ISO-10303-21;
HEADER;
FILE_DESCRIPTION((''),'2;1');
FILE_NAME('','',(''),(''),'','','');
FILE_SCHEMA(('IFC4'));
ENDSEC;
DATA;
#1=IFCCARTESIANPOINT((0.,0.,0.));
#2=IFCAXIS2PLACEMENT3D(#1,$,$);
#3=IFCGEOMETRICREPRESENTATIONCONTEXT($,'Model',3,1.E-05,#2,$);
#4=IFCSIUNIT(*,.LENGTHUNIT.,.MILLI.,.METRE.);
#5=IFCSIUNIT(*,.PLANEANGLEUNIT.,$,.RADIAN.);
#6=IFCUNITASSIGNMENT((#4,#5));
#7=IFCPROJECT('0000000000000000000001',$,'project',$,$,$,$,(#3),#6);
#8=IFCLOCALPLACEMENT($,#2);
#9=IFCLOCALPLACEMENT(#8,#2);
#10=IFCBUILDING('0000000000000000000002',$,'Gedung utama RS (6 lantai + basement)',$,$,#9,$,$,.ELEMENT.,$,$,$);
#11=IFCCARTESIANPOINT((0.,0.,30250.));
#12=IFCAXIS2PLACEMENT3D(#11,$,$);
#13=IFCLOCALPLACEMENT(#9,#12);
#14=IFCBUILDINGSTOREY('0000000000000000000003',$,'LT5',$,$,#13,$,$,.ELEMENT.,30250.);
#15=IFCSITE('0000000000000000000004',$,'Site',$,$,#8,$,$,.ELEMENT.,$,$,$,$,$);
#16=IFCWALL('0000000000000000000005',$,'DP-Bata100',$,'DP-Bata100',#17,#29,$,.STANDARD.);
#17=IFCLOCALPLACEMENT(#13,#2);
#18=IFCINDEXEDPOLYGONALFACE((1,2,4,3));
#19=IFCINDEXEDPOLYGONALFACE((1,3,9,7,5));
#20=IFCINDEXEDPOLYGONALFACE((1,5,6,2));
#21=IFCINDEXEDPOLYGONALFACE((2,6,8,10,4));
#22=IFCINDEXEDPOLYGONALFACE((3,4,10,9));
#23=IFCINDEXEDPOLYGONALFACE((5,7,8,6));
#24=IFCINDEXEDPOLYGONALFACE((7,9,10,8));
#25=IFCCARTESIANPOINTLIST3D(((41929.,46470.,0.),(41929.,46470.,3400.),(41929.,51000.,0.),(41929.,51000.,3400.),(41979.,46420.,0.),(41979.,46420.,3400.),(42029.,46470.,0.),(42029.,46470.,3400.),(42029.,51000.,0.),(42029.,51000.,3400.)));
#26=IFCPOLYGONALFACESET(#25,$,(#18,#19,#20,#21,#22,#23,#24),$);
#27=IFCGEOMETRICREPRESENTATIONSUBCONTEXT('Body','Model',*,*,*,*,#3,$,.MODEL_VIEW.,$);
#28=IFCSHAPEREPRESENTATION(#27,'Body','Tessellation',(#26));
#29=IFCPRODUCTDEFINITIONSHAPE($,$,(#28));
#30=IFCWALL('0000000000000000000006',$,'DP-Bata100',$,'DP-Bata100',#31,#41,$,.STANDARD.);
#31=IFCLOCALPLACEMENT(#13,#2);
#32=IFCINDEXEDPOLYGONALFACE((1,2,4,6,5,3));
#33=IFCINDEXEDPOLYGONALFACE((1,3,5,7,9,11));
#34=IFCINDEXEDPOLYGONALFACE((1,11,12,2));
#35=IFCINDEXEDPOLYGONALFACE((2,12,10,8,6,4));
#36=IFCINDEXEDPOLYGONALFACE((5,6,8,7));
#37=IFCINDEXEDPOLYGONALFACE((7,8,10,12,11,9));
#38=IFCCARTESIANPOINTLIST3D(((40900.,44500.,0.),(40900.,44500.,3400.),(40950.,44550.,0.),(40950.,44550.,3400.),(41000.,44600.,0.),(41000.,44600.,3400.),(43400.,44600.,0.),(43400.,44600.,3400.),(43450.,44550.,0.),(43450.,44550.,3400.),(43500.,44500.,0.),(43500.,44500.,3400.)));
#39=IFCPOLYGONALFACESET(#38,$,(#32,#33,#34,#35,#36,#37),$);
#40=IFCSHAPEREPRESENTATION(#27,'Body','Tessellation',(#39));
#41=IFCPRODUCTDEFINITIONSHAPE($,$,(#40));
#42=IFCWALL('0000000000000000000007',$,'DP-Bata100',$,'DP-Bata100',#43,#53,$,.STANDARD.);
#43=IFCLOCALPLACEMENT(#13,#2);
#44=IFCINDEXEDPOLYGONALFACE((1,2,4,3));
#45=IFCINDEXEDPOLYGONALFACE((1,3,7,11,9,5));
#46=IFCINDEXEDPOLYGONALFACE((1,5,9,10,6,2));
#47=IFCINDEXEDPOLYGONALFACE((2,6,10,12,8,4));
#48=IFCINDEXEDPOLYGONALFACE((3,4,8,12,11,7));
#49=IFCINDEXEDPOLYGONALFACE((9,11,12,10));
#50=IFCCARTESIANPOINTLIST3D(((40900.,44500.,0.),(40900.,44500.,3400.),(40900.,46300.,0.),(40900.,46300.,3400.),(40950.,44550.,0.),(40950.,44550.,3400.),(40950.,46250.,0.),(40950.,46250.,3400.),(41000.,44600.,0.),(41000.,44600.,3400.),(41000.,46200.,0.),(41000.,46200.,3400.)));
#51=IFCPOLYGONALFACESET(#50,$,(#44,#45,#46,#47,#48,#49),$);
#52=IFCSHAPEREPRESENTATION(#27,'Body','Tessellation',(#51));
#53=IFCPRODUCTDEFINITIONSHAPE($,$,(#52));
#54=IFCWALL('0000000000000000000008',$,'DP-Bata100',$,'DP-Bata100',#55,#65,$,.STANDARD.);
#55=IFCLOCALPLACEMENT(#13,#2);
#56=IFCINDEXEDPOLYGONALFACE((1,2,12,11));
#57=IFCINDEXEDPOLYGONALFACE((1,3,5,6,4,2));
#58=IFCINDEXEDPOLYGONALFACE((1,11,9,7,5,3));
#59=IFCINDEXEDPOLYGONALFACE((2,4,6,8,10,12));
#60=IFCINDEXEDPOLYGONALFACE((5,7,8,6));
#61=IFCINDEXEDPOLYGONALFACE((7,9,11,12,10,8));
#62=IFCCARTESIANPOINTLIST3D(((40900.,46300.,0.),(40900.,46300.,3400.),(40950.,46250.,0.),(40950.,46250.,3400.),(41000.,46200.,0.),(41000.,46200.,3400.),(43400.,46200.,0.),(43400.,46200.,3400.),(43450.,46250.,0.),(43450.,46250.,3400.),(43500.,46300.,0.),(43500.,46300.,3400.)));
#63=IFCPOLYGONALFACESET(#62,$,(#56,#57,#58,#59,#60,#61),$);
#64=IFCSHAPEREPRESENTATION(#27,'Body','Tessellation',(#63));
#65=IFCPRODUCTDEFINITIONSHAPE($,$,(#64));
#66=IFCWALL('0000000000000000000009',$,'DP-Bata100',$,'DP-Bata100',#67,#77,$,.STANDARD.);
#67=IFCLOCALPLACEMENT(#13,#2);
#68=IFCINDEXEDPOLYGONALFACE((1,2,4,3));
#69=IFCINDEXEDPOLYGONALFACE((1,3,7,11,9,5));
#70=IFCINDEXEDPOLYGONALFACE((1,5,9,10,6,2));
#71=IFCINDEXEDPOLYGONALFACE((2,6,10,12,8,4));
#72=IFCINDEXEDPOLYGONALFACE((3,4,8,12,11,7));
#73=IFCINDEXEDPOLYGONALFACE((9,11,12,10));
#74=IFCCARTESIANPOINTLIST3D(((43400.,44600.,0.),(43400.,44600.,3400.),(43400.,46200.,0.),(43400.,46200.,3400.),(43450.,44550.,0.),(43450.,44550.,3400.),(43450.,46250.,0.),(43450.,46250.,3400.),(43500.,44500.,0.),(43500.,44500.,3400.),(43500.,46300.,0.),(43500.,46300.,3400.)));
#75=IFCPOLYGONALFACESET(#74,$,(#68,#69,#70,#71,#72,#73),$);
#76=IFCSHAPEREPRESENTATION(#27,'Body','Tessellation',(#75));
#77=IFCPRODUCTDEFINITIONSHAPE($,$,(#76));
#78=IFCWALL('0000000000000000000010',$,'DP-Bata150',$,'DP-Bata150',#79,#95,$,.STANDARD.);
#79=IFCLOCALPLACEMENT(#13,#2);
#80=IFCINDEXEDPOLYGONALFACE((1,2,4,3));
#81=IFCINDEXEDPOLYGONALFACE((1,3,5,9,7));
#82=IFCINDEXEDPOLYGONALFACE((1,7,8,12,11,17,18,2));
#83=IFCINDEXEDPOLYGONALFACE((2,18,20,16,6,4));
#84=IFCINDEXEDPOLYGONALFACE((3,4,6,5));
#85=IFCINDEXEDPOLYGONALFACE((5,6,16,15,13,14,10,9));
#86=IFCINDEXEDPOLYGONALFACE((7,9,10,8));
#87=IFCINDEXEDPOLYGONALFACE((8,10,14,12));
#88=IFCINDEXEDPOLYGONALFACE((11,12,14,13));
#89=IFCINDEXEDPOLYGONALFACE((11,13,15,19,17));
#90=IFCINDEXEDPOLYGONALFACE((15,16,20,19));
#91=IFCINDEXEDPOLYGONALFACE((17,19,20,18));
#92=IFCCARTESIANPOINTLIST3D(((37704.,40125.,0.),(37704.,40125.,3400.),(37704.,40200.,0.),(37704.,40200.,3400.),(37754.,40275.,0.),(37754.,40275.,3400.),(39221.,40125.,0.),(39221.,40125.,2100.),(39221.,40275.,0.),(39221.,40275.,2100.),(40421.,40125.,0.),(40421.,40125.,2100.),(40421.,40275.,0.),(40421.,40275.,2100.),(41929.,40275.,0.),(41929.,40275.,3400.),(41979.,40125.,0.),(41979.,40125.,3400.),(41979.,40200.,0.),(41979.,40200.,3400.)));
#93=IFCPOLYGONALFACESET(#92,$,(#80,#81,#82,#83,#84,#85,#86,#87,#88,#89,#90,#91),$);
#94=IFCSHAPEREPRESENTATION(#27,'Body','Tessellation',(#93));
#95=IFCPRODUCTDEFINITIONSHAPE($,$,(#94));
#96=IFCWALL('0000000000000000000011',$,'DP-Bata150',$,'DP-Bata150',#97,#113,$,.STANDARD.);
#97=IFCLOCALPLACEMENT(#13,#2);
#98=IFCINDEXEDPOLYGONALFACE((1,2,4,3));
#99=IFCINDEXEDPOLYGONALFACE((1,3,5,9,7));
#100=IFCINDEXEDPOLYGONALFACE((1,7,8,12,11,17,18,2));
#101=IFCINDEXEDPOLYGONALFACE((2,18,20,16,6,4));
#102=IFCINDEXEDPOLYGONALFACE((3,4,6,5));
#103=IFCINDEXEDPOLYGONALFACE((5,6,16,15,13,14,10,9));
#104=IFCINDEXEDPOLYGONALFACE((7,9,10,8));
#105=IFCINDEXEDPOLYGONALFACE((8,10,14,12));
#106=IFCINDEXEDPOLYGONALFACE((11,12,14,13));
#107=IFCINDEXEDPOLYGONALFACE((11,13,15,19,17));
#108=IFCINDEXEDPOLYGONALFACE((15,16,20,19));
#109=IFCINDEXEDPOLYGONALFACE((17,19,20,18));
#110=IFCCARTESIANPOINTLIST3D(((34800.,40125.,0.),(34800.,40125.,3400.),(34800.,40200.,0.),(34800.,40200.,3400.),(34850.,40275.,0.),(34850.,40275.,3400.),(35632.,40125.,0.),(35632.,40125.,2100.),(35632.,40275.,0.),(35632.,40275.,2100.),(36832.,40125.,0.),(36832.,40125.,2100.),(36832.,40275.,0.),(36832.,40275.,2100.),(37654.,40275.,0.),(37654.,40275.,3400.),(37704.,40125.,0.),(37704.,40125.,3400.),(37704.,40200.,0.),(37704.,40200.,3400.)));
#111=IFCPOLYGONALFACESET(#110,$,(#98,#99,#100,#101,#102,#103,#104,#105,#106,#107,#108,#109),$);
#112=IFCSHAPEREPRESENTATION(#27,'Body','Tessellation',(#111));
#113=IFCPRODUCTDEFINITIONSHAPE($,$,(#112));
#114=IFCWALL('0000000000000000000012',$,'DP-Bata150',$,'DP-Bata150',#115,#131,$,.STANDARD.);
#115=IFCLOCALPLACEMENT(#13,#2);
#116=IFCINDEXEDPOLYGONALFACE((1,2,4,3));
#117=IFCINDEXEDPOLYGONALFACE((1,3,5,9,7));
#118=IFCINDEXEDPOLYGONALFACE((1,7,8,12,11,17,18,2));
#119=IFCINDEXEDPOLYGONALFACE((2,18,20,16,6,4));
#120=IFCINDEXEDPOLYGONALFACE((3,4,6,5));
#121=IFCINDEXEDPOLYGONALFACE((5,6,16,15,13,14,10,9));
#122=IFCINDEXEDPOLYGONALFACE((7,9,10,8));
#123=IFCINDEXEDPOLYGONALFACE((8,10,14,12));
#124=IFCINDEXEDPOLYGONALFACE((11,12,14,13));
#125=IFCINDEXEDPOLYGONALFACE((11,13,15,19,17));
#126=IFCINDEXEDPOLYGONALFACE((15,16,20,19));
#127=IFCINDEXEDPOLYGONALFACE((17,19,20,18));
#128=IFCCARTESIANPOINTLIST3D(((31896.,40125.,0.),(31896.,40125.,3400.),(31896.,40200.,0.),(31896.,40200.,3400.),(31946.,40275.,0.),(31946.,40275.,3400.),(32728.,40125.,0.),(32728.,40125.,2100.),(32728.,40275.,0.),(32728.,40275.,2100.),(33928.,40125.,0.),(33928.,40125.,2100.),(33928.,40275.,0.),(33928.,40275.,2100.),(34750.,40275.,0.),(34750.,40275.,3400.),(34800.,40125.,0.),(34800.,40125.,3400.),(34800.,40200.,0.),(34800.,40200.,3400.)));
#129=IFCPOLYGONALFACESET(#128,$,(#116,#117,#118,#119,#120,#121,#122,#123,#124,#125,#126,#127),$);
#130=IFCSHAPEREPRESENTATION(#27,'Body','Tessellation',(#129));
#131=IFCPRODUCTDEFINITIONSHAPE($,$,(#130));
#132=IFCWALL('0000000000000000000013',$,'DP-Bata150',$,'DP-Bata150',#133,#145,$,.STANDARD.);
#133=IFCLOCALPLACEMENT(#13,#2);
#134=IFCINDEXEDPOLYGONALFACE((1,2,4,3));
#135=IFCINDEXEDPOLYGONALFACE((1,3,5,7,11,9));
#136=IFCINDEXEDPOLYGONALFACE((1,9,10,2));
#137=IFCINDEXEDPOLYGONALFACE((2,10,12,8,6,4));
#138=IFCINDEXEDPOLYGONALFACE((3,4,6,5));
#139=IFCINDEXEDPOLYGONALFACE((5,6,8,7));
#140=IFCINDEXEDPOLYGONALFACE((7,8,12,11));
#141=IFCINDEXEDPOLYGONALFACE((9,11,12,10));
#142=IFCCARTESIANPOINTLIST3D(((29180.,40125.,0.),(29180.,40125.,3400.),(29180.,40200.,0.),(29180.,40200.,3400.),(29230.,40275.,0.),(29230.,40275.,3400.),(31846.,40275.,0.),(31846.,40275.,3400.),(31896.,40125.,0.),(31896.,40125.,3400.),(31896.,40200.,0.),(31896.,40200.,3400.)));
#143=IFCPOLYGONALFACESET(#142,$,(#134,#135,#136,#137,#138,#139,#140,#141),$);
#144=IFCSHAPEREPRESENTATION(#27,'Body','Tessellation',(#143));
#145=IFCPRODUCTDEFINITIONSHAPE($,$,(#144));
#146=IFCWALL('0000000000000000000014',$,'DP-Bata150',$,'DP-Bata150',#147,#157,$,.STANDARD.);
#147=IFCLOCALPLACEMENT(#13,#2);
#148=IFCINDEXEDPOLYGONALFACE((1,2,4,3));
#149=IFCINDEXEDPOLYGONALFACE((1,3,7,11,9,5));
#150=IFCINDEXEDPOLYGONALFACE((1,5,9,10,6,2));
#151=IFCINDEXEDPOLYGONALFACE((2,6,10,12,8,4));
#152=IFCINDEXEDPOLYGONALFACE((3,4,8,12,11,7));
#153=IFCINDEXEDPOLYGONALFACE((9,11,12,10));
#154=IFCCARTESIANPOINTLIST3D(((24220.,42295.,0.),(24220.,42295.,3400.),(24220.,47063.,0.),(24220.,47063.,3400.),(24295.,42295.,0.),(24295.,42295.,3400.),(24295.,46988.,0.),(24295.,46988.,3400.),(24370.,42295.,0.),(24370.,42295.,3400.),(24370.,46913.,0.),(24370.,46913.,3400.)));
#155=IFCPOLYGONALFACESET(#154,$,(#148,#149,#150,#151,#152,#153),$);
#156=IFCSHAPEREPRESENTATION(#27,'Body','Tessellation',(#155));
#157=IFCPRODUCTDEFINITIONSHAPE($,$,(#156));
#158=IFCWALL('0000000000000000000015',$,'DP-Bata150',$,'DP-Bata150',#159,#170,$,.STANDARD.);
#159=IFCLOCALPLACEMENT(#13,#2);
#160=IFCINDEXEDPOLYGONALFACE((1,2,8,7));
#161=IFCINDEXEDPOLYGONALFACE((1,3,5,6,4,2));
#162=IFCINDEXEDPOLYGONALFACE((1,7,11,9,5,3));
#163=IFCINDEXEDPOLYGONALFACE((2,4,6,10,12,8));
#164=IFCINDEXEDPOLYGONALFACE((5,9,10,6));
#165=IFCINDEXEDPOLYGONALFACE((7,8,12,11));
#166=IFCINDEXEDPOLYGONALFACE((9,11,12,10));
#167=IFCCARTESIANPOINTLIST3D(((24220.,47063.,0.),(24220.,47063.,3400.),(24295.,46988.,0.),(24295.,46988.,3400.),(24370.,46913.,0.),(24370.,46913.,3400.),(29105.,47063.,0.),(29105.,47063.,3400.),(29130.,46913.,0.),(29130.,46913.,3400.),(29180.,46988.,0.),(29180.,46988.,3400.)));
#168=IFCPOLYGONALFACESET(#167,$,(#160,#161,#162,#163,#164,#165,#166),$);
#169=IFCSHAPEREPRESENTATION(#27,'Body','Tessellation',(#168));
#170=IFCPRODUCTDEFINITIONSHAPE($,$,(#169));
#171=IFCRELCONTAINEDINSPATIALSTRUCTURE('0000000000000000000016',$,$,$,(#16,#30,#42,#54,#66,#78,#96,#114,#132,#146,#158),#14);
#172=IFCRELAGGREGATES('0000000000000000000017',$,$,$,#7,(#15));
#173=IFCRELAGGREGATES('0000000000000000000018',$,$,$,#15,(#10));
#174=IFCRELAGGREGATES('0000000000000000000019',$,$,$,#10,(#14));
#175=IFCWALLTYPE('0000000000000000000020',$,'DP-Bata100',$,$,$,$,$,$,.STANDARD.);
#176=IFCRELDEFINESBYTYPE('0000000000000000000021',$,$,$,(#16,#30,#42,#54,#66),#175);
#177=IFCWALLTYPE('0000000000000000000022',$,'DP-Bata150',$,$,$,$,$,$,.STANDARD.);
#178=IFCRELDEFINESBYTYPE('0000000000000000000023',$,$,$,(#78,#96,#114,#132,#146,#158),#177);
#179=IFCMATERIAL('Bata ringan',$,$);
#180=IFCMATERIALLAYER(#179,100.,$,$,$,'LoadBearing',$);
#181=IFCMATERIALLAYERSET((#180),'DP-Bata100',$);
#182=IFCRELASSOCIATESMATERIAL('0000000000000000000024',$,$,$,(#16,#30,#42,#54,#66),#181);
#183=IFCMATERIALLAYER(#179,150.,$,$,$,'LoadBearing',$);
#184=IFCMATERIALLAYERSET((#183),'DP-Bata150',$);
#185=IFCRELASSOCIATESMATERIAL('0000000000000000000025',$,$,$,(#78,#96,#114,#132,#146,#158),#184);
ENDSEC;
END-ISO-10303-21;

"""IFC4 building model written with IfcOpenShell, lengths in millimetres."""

from ifc_helpers import new_model, si_unit, frame, frame_2d, origin, place, context, subcontext, project, spatial, polyline, rectangle, outline, extrude, material, layer, layer_set, layer_usage, type_object, element, save


model = new_model("IFC4")

# Units and contexts
model_context = context("Model", 3, precision=1e-05, world=origin())
body_context = subcontext(model_context, "Body", "Model", "MODEL_VIEW")
ifc_project = project(units=[si_unit("LENGTHUNIT", "METRE", prefix="MILLI"), si_unit("PLANEANGLEUNIT", "RADIAN")], contexts=[model_context])

# Site, building, storey
site_placement = place(None, origin())
site = spatial("IfcSite", under=ifc_project, at=site_placement, Name="Site", CompositionType="ELEMENT")
building_placement = place(site_placement, origin())
building = spatial("IfcBuilding", under=site, at=building_placement, Name="Gedung utama RS (6 lantai + basement)", CompositionType="ELEMENT")
storey_placement = place(building_placement, frame((0.0, 0.0, 30250.0)))
storey = spatial("IfcBuildingStorey", under=building, at=storey_placement, Name="LT5", CompositionType="ELEMENT", Elevation=30250.0)

# Walls
ifc_material_1 = material(Name="Bata ringan")
ifc_layer_1 = layer(ifc_material_1, 100.0, Category="LoadBearing")
ifc_layer_set_1 = layer_set([ifc_layer_1], Name="DP-Bata100")
ifc_layer_usage_1 = layer_usage(ifc_layer_set_1, "AXIS2", "NEGATIVE", 50.0)
wall_type_1 = type_object("IfcWallType", Name="DP-Bata100", PredefinedType="STANDARD")
wall_1_placement = place(storey_placement, frame((41979.0, 51000.0, 0.0), z_axis=(0.0, 0.0, 1.0), x_axis=(0.0, -1.0, 0.0)))
element("IfcWall", 1, at=wall_1_placement, inside=storey, type_object=wall_type_1, material=ifc_layer_usage_1, Name="DP-Bata100", ObjectType="DP-Bata100", PredefinedType="STANDARD", context=body_context, shape_type="SweptSolid", body=[
    extrude(outline(polyline([(0.0, -50.0), (0.0, 50.0), (4530.0, 50.0), (4580.0, 0.0), (4530.0, -50.0), (0.0, -50.0)])), origin(), (0.0, 0.0, 1.0), 3400.0),
])
wall_2_placement = place(storey_placement, frame((43450.0, 44550.0, 0.0), z_axis=(0.0, 0.0, 1.0), x_axis=(-1.0, 0.0, 0.0)))
element("IfcWall", 2, at=wall_2_placement, inside=storey, type_object=wall_type_1, material=ifc_layer_usage_1, Name="DP-Bata100", ObjectType="DP-Bata100", PredefinedType="STANDARD", context=body_context, shape_type="SweptSolid", body=[
    extrude(outline(polyline([(50.0, -50.0), (0.0, 0.0), (-50.0, 50.0), (2550.0, 50.0), (2500.0, 0.0), (2450.0, -50.0), (50.0, -50.0)])), origin(), (0.0, 0.0, 1.0), 3400.0),
])
wall_3_placement = place(storey_placement, frame((40950.0, 44550.0, 0.0), z_axis=(0.0, 0.0, 1.0), x_axis=(0.0, 1.0, 0.0)))
element("IfcWall", 3, at=wall_3_placement, inside=storey, type_object=wall_type_1, material=ifc_layer_usage_1, Name="DP-Bata100", ObjectType="DP-Bata100", PredefinedType="STANDARD", context=body_context, shape_type="SweptSolid", body=[
    extrude(outline(polyline([(50.0, -50.0), (0.0, 0.0), (-50.0, 50.0), (1750.0, 50.0), (1700.0, 0.0), (1650.0, -50.0), (50.0, -50.0)])), origin(), (0.0, 0.0, 1.0), 3400.0),
])
wall_4_placement = place(storey_placement, frame((40950.0, 46250.0, 0.0), z_axis=(0.0, 0.0, 1.0), x_axis=(1.0, 0.0, 0.0)))
element("IfcWall", 4, at=wall_4_placement, inside=storey, type_object=wall_type_1, material=ifc_layer_usage_1, Name="DP-Bata100", ObjectType="DP-Bata100", PredefinedType="STANDARD", context=body_context, shape_type="SweptSolid", body=[
    extrude(outline(polyline([(50.0, -50.0), (0.0, 0.0), (-50.0, 50.0), (2550.0, 50.0), (2500.0, 0.0), (2450.0, -50.0), (50.0, -50.0)])), origin(), (0.0, 0.0, 1.0), 3400.0),
])
wall_5_placement = place(storey_placement, frame((43450.0, 46250.0, 0.0), z_axis=(0.0, 0.0, 1.0), x_axis=(0.0, -1.0, 0.0)))
element("IfcWall", 5, at=wall_5_placement, inside=storey, type_object=wall_type_1, material=ifc_layer_usage_1, Name="DP-Bata100", ObjectType="DP-Bata100", PredefinedType="STANDARD", context=body_context, shape_type="SweptSolid", body=[
    extrude(outline(polyline([(50.0, -50.0), (0.0, 0.0), (-50.0, 50.0), (1750.0, 50.0), (1700.0, 0.0), (1650.0, -50.0), (50.0, -50.0)])), origin(), (0.0, 0.0, 1.0), 3400.0),
])

# Walls, openings
ifc_layer_2 = layer(ifc_material_1, 150.0, Category="LoadBearing")
ifc_layer_set_2 = layer_set([ifc_layer_2], Name="DP-Bata150")
ifc_layer_usage_2 = layer_usage(ifc_layer_set_2, "AXIS2", "NEGATIVE", 75.0)
wall_type_2 = type_object("IfcWallType", Name="DP-Bata150", PredefinedType="STANDARD")
wall_6_placement = place(storey_placement, frame((41979.0, 40200.0, 0.0), z_axis=(0.0, 0.0, 1.0), x_axis=(-1.0, 0.0, 0.0)))
wall_6 = element("IfcWall", 6, at=wall_6_placement, inside=storey, type_object=wall_type_2, material=ifc_layer_usage_2, Name="DP-Bata150", ObjectType="DP-Bata150", PredefinedType="STANDARD", context=body_context, shape_type="SweptSolid", body=[
    extrude(outline(polyline([(50.0, -75.0), (0.0, 0.0), (0.0, 75.0), (4275.0, 75.0), (4275.0, 0.0), (4225.0, -75.0), (50.0, -75.0)])), origin(), (0.0, 0.0, 1.0), 3400.0),
])
opening_1_placement = place(wall_6_placement, frame((1558.0, 0.0, 0.0), z_axis=(0.0, 0.0, 1.0), x_axis=(1.0, 0.0, 0.0)))
element("IfcOpeningElement", 7, at=opening_1_placement, cuts=wall_6, PredefinedType="OPENING", context=body_context, shape_type="SweptSolid", body=[
    extrude(rectangle(XDim=1200.0, YDim=170.0, at=frame_2d((600.0, 0.0))), origin(), (0.0, 0.0, 1.0), 2100.0),
])
wall_7_placement = place(storey_placement, frame((37704.0, 40200.0, 0.0), z_axis=(0.0, 0.0, 1.0), x_axis=(-1.0, 0.0, 0.0)))
wall_7 = element("IfcWall", 8, at=wall_7_placement, inside=storey, type_object=wall_type_2, material=ifc_layer_usage_2, Name="DP-Bata150", ObjectType="DP-Bata150", PredefinedType="STANDARD", context=body_context, shape_type="SweptSolid", body=[
    extrude(outline(polyline([(50.0, -75.0), (0.0, 0.0), (0.0, 75.0), (2904.0, 75.0), (2904.0, 0.0), (2854.0, -75.0), (50.0, -75.0)])), origin(), (0.0, 0.0, 1.0), 3400.0),
])
opening_2_placement = place(wall_7_placement, frame((872.0, 0.0, 0.0), z_axis=(0.0, 0.0, 1.0), x_axis=(1.0, 0.0, 0.0)))
element("IfcOpeningElement", 9, at=opening_2_placement, cuts=wall_7, PredefinedType="OPENING", context=body_context, shape_type="SweptSolid", body=[
    extrude(rectangle(XDim=1200.0, YDim=170.0, at=frame_2d((600.0, 0.0))), origin(), (0.0, 0.0, 1.0), 2100.0),
])
wall_8_placement = place(storey_placement, frame((34800.0, 40200.0, 0.0), z_axis=(0.0, 0.0, 1.0), x_axis=(-1.0, 0.0, 0.0)))
wall_8 = element("IfcWall", 10, at=wall_8_placement, inside=storey, type_object=wall_type_2, material=ifc_layer_usage_2, Name="DP-Bata150", ObjectType="DP-Bata150", PredefinedType="STANDARD", context=body_context, shape_type="SweptSolid", body=[
    extrude(outline(polyline([(50.0, -75.0), (0.0, 0.0), (0.0, 75.0), (2904.0, 75.0), (2904.0, 0.0), (2854.0, -75.0), (50.0, -75.0)])), origin(), (0.0, 0.0, 1.0), 3400.0),
])
opening_3_placement = place(wall_8_placement, frame((872.0, 0.0, 0.0), z_axis=(0.0, 0.0, 1.0), x_axis=(1.0, 0.0, 0.0)))
element("IfcOpeningElement", 11, at=opening_3_placement, cuts=wall_8, PredefinedType="OPENING", context=body_context, shape_type="SweptSolid", body=[
    extrude(rectangle(XDim=1200.0, YDim=170.0, at=frame_2d((600.0, 0.0))), origin(), (0.0, 0.0, 1.0), 2100.0),
])

# Walls
wall_9_placement = place(storey_placement, frame((31896.0, 40200.0, 0.0), z_axis=(0.0, 0.0, 1.0), x_axis=(-1.0, 0.0, 0.0)))
element("IfcWall", 12, at=wall_9_placement, inside=storey, type_object=wall_type_2, material=ifc_layer_usage_2, Name="DP-Bata150", ObjectType="DP-Bata150", PredefinedType="STANDARD", context=body_context, shape_type="SweptSolid", body=[
    extrude(outline(polyline([(50.0, -75.0), (0.0, 0.0), (0.0, 75.0), (2716.0, 75.0), (2716.0, 0.0), (2666.0, -75.0), (50.0, -75.0)])), origin(), (0.0, 0.0, 1.0), 3400.0),
])
wall_10_placement = place(storey_placement, frame((24295.0, 42295.0, 0.0), z_axis=(0.0, 0.0, 1.0), x_axis=(0.0, 1.0, 0.0)))
element("IfcWall", 13, at=wall_10_placement, inside=storey, type_object=wall_type_2, material=ifc_layer_usage_2, Name="DP-Bata150", ObjectType="DP-Bata150", PredefinedType="STANDARD", context=body_context, shape_type="SweptSolid", body=[
    extrude(outline(polyline([(0.0, -75.0), (0.0, 0.0), (0.0, 75.0), (4768.0, 75.0), (4693.0, 0.0), (4618.0, -75.0), (0.0, -75.0)])), origin(), (0.0, 0.0, 1.0), 3400.0),
])
wall_11_placement = place(storey_placement, frame((24295.0, 46988.0, 0.0), z_axis=(0.0, 0.0, 1.0), x_axis=(1.0, 0.0, 0.0)))
element("IfcWall", 14, at=wall_11_placement, inside=storey, type_object=wall_type_2, material=ifc_layer_usage_2, Name="DP-Bata150", ObjectType="DP-Bata150", PredefinedType="STANDARD", context=body_context, shape_type="SweptSolid", body=[
    extrude(outline(polyline([(75.0, -75.0), (0.0, 0.0), (-75.0, 75.0), (4810.0, 75.0), (4885.0, 0.0), (4835.0, -75.0), (75.0, -75.0)])), origin(), (0.0, 0.0, 1.0), 3400.0),
])

save(model, "model.ifc")
